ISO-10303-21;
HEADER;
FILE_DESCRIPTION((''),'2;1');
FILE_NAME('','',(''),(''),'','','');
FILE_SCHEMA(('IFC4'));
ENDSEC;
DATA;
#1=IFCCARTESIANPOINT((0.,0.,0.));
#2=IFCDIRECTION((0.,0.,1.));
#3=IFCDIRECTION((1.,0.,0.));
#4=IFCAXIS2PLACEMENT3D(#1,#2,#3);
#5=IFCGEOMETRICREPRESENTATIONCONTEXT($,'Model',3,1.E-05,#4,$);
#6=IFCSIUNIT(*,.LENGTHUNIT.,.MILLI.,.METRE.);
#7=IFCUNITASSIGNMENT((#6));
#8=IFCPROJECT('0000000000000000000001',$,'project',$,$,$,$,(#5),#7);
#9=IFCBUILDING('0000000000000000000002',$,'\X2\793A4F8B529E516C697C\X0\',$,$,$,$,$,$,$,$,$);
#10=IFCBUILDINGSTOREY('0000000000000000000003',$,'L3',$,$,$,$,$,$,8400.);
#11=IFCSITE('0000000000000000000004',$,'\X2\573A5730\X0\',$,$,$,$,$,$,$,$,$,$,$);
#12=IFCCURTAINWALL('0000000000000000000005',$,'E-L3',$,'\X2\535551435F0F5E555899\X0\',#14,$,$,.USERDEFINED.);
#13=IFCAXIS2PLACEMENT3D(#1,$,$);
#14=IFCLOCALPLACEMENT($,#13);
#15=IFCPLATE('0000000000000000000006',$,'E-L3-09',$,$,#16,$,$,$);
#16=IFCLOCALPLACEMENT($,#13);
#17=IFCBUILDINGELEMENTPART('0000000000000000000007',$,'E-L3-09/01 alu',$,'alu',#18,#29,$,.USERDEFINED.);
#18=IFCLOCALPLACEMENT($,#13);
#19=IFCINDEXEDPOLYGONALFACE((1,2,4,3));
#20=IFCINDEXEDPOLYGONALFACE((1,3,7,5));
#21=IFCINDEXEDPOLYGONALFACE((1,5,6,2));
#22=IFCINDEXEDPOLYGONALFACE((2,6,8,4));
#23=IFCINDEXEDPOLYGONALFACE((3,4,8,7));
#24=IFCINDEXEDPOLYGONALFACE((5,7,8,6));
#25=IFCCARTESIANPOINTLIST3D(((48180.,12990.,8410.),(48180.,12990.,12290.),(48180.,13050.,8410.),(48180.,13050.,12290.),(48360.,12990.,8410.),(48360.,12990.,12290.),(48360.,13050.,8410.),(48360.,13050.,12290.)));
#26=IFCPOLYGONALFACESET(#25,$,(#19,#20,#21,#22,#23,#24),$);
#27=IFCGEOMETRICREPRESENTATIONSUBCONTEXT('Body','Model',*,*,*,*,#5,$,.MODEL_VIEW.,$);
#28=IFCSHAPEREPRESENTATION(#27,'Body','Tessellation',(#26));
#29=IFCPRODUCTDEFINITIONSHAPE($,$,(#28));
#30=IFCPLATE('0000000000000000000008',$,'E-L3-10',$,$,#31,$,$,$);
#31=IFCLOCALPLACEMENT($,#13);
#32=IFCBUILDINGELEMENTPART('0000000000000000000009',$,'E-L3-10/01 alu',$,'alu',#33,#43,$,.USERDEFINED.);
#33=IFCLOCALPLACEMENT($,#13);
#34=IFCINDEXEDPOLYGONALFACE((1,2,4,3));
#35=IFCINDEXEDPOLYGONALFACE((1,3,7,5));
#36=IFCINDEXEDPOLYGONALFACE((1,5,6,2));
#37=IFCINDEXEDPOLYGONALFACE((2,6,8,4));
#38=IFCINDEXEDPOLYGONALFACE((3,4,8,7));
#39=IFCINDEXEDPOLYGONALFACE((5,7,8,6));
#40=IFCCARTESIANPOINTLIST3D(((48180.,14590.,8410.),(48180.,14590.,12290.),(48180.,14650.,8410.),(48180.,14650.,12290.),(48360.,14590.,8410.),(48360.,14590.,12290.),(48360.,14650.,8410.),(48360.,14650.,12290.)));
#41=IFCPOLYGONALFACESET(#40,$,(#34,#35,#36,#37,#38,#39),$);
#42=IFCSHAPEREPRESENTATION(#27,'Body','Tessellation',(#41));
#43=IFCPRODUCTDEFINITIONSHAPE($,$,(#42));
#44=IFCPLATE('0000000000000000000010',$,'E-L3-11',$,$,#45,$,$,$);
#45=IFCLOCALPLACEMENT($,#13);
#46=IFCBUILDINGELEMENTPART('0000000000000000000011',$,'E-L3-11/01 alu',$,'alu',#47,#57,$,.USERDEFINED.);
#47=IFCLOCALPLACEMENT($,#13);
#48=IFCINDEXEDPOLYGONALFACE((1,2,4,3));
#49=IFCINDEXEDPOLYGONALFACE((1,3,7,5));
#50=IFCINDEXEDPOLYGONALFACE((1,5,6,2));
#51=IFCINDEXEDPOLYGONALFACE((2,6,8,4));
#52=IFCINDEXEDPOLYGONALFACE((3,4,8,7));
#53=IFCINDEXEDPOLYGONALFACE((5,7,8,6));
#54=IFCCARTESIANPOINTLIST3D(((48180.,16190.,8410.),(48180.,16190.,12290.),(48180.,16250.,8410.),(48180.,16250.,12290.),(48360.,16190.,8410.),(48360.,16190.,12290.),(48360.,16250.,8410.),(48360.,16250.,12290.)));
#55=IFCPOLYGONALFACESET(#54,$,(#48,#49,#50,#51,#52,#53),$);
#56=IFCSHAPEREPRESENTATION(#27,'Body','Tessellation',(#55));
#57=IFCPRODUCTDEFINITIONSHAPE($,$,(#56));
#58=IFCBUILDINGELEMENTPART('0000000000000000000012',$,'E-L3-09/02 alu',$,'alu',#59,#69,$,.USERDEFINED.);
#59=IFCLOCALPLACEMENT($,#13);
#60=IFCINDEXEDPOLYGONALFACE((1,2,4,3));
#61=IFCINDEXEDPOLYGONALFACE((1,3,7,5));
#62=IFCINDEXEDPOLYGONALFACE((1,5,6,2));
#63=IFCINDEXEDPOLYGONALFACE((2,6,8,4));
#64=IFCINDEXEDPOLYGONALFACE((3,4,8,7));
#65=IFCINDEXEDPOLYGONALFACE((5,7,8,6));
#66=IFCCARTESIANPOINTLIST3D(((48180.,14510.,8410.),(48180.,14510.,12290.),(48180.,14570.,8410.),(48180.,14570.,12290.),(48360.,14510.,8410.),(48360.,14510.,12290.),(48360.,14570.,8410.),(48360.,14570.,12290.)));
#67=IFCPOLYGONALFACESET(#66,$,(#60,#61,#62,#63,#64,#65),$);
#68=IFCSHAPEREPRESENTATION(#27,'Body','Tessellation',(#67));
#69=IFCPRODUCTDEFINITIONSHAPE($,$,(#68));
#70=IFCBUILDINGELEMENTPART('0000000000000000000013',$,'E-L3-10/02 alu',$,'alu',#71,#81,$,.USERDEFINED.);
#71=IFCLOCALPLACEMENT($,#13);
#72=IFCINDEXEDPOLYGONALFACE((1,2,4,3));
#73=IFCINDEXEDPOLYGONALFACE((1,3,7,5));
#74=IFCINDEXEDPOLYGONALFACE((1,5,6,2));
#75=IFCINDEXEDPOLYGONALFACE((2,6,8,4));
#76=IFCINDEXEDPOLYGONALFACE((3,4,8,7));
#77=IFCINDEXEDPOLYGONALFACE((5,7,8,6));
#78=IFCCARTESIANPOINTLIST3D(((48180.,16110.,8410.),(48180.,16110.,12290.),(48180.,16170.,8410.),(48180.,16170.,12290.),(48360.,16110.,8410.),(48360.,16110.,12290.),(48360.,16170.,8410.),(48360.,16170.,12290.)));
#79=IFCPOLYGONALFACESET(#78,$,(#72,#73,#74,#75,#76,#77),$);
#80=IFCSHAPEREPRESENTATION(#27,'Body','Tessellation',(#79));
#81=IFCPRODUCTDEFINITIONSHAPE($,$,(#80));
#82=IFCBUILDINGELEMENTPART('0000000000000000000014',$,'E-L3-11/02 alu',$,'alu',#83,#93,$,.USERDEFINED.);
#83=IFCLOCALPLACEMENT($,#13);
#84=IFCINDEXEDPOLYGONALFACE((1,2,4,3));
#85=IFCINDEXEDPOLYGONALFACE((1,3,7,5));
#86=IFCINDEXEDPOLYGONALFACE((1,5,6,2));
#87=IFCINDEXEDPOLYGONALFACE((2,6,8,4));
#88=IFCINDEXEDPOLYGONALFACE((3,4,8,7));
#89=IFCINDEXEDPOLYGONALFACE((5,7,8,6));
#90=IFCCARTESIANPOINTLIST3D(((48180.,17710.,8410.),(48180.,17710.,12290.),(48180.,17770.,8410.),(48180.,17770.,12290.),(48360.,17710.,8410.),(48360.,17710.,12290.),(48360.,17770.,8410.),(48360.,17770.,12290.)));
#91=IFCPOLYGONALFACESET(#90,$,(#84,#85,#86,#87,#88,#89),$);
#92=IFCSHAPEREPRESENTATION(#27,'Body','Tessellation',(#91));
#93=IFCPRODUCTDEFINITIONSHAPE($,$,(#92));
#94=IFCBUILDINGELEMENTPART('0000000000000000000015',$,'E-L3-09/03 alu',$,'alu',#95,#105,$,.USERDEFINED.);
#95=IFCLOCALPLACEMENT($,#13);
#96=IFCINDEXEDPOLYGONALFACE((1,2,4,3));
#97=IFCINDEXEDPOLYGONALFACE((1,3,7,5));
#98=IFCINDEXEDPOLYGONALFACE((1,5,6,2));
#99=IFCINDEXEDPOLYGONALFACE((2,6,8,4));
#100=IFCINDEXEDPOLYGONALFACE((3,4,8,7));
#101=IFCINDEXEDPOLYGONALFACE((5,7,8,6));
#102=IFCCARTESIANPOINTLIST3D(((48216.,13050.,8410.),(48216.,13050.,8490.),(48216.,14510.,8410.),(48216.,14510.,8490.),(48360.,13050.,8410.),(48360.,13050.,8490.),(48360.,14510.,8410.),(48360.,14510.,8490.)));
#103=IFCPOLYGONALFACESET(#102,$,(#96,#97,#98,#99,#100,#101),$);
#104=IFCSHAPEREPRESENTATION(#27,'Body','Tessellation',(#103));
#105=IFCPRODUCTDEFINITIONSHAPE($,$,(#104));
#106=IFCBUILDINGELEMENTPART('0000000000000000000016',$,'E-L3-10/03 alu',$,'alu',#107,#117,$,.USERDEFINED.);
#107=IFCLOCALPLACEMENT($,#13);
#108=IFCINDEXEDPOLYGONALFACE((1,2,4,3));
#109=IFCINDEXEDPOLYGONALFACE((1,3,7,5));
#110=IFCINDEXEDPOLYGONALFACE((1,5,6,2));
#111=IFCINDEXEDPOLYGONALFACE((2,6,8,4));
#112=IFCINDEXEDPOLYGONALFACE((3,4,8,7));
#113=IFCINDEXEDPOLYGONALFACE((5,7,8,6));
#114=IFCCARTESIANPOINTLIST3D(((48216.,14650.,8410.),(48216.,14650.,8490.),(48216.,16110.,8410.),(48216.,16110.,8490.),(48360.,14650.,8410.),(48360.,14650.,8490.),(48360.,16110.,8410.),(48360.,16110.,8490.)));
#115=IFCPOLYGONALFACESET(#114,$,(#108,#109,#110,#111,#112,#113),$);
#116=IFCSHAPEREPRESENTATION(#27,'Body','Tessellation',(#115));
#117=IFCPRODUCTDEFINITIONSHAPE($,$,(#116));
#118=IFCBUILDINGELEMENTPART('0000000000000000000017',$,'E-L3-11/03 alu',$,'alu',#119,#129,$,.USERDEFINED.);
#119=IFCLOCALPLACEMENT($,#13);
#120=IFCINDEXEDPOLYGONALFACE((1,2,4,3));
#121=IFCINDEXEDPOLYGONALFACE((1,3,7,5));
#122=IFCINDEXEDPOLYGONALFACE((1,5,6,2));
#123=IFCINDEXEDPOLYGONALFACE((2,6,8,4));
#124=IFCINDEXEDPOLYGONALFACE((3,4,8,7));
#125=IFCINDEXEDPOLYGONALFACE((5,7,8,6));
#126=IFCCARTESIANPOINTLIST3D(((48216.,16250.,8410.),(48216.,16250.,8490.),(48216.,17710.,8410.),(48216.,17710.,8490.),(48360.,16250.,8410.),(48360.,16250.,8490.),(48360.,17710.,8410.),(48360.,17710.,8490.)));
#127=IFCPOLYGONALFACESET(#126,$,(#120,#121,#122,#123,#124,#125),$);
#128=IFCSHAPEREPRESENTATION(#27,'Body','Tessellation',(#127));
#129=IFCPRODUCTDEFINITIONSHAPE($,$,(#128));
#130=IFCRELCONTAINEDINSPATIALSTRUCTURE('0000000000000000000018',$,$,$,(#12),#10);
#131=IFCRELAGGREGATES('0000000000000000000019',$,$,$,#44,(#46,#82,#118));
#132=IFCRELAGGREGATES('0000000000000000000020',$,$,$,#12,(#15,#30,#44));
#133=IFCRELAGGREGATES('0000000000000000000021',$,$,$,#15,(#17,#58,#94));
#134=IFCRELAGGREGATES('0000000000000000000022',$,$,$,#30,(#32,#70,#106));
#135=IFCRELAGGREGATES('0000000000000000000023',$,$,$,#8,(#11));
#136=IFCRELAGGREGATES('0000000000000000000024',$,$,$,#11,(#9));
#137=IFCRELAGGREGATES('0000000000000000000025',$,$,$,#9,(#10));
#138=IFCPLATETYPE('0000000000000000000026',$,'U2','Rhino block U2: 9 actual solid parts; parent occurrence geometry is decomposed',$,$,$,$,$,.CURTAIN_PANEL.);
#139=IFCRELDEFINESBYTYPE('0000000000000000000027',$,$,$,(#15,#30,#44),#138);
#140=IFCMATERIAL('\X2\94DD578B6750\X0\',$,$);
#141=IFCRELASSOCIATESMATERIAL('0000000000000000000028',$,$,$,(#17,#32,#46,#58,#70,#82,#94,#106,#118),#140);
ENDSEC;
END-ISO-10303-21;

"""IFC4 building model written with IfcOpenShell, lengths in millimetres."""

from ifc_helpers import new_model, si_unit, frame, frame_2d, origin, origin_with_axes, place, context, subcontext, project, spatial, rectangle, extrude, source, transform, mapped, material, type_object, element, aggregate, save


model = new_model("IFC4")

# Units and contexts
model_context = context("Model", 3, precision=1e-05, world=origin_with_axes())
body_context = subcontext(model_context, "Body", "Model", "MODEL_VIEW")
ifc_project = project(units=[si_unit("LENGTHUNIT", "METRE", prefix="MILLI")], contexts=[model_context])

# Site, building, storey
site = spatial("IfcSite", under=ifc_project, Name="场地")
building = spatial("IfcBuilding", under=site, Name="示例办公楼")
storey = spatial("IfcBuildingStorey", under=building, Name="L3", Elevation=8400.0)

# Curtain wall, plates, building element parts
curtain_wall = element("IfcCurtainWall", 1, inside=storey, Name="E-L3", ObjectType="单元式幕墙", PredefinedType="USERDEFINED")
plate_type = type_object("IfcPlateType", Name="U2", Description="Rhino block U2: 9 actual solid parts; parent occurrence geometry is decomposed", PredefinedType="CURTAIN_PANEL")
plate_1_placement = place(None, frame((48360.0, 12990.0, 8410.0), z_axis=(0.0, 0.0, 1.0), x_axis=(0.0, 1.0, 0.0)))
plate_1 = element("IfcPlate", 2, at=plate_1_placement, type_object=plate_type, Name="E-L3-09")
ifc_material_1 = material(Name="铝型材")
shared_shape_1 = source(origin(), body_context, "Body", "SweptSolid", [
    extrude(rectangle(XDim=60.0, YDim=180.0, at=frame_2d((30.0, 90.0))), origin(), (0.0, 0.0, 1.0), 3880.0),
])
building_element_part_1_placement = place(plate_1_placement, origin())
building_element_part_1 = element("IfcBuildingElementPart", 3, at=building_element_part_1_placement, material=ifc_material_1, Name="E-L3-09/01 alu", ObjectType="alu", PredefinedType="USERDEFINED", context=body_context, shape_type="MappedRepresentation", body=[
    mapped(shared_shape_1, transform((0.0, 0.0, 0.0))),
])
plate_2_placement = place(None, frame((48360.0, 14590.0, 8410.0), z_axis=(0.0, 0.0, 1.0), x_axis=(0.0, 1.0, 0.0)))
plate_2 = element("IfcPlate", 4, at=plate_2_placement, type_object=plate_type, Name="E-L3-10")
building_element_part_2_placement = place(plate_2_placement, origin())
building_element_part_2 = element("IfcBuildingElementPart", 5, at=building_element_part_2_placement, material=ifc_material_1, Name="E-L3-10/01 alu", ObjectType="alu", PredefinedType="USERDEFINED", context=body_context, shape_type="MappedRepresentation", body=[
    mapped(shared_shape_1, transform((0.0, 0.0, 0.0))),
])
plate_3_placement = place(None, frame((48360.0, 16190.0, 8410.0), z_axis=(0.0, 0.0, 1.0), x_axis=(0.0, 1.0, 0.0)))
plate_3 = element("IfcPlate", 6, at=plate_3_placement, type_object=plate_type, Name="E-L3-11")
building_element_part_3_placement = place(plate_3_placement, origin())
building_element_part_3 = element("IfcBuildingElementPart", 7, at=building_element_part_3_placement, material=ifc_material_1, Name="E-L3-11/01 alu", ObjectType="alu", PredefinedType="USERDEFINED", context=body_context, shape_type="MappedRepresentation", body=[
    mapped(shared_shape_1, transform((0.0, 0.0, 0.0))),
])
shared_shape_2 = source(origin(), body_context, "Body", "SweptSolid", [
    extrude(rectangle(XDim=60.0, YDim=180.0, at=frame_2d((1550.0, 90.0))), origin(), (0.0, 0.0, 1.0), 3880.0),
])
building_element_part_4_placement = place(plate_1_placement, origin())
building_element_part_4 = element("IfcBuildingElementPart", 8, at=building_element_part_4_placement, material=ifc_material_1, Name="E-L3-09/02 alu", ObjectType="alu", PredefinedType="USERDEFINED", context=body_context, shape_type="MappedRepresentation", body=[
    mapped(shared_shape_2, transform((0.0, 0.0, 0.0))),
])
building_element_part_5_placement = place(plate_2_placement, origin())
building_element_part_5 = element("IfcBuildingElementPart", 9, at=building_element_part_5_placement, material=ifc_material_1, Name="E-L3-10/02 alu", ObjectType="alu", PredefinedType="USERDEFINED", context=body_context, shape_type="MappedRepresentation", body=[
    mapped(shared_shape_2, transform((0.0, 0.0, 0.0))),
])
building_element_part_6_placement = place(plate_3_placement, origin())
building_element_part_6 = element("IfcBuildingElementPart", 10, at=building_element_part_6_placement, material=ifc_material_1, Name="E-L3-11/02 alu", ObjectType="alu", PredefinedType="USERDEFINED", context=body_context, shape_type="MappedRepresentation", body=[
    mapped(shared_shape_2, transform((0.0, 0.0, 0.0))),
])
shared_shape_3 = source(origin(), body_context, "Body", "SweptSolid", [
    extrude(rectangle(XDim=1460.0, YDim=144.0, at=frame_2d((790.0, 72.0))), origin(), (0.0, 0.0, 1.0), 80.0),
])
building_element_part_7_placement = place(plate_1_placement, origin())
building_element_part_7 = element("IfcBuildingElementPart", 11, at=building_element_part_7_placement, material=ifc_material_1, Name="E-L3-09/03 alu", ObjectType="alu", PredefinedType="USERDEFINED", context=body_context, shape_type="MappedRepresentation", body=[
    mapped(shared_shape_3, transform((0.0, 0.0, 0.0))),
])
building_element_part_8_placement = place(plate_2_placement, origin())
building_element_part_8 = element("IfcBuildingElementPart", 12, at=building_element_part_8_placement, material=ifc_material_1, Name="E-L3-10/03 alu", ObjectType="alu", PredefinedType="USERDEFINED", context=body_context, shape_type="MappedRepresentation", body=[
    mapped(shared_shape_3, transform((0.0, 0.0, 0.0))),
])
building_element_part_9_placement = place(plate_3_placement, origin())
building_element_part_9 = element("IfcBuildingElementPart", 13, at=building_element_part_9_placement, material=ifc_material_1, Name="E-L3-11/03 alu", ObjectType="alu", PredefinedType="USERDEFINED", context=body_context, shape_type="MappedRepresentation", body=[
    mapped(shared_shape_3, transform((0.0, 0.0, 0.0))),
])
aggregate(plate_3, [building_element_part_3, building_element_part_6, building_element_part_9])
aggregate(curtain_wall, [plate_1, plate_2, plate_3])
aggregate(plate_1, [building_element_part_1, building_element_part_4, building_element_part_7])
aggregate(plate_2, [building_element_part_2, building_element_part_5, building_element_part_8])

save(model, "model.ifc")
